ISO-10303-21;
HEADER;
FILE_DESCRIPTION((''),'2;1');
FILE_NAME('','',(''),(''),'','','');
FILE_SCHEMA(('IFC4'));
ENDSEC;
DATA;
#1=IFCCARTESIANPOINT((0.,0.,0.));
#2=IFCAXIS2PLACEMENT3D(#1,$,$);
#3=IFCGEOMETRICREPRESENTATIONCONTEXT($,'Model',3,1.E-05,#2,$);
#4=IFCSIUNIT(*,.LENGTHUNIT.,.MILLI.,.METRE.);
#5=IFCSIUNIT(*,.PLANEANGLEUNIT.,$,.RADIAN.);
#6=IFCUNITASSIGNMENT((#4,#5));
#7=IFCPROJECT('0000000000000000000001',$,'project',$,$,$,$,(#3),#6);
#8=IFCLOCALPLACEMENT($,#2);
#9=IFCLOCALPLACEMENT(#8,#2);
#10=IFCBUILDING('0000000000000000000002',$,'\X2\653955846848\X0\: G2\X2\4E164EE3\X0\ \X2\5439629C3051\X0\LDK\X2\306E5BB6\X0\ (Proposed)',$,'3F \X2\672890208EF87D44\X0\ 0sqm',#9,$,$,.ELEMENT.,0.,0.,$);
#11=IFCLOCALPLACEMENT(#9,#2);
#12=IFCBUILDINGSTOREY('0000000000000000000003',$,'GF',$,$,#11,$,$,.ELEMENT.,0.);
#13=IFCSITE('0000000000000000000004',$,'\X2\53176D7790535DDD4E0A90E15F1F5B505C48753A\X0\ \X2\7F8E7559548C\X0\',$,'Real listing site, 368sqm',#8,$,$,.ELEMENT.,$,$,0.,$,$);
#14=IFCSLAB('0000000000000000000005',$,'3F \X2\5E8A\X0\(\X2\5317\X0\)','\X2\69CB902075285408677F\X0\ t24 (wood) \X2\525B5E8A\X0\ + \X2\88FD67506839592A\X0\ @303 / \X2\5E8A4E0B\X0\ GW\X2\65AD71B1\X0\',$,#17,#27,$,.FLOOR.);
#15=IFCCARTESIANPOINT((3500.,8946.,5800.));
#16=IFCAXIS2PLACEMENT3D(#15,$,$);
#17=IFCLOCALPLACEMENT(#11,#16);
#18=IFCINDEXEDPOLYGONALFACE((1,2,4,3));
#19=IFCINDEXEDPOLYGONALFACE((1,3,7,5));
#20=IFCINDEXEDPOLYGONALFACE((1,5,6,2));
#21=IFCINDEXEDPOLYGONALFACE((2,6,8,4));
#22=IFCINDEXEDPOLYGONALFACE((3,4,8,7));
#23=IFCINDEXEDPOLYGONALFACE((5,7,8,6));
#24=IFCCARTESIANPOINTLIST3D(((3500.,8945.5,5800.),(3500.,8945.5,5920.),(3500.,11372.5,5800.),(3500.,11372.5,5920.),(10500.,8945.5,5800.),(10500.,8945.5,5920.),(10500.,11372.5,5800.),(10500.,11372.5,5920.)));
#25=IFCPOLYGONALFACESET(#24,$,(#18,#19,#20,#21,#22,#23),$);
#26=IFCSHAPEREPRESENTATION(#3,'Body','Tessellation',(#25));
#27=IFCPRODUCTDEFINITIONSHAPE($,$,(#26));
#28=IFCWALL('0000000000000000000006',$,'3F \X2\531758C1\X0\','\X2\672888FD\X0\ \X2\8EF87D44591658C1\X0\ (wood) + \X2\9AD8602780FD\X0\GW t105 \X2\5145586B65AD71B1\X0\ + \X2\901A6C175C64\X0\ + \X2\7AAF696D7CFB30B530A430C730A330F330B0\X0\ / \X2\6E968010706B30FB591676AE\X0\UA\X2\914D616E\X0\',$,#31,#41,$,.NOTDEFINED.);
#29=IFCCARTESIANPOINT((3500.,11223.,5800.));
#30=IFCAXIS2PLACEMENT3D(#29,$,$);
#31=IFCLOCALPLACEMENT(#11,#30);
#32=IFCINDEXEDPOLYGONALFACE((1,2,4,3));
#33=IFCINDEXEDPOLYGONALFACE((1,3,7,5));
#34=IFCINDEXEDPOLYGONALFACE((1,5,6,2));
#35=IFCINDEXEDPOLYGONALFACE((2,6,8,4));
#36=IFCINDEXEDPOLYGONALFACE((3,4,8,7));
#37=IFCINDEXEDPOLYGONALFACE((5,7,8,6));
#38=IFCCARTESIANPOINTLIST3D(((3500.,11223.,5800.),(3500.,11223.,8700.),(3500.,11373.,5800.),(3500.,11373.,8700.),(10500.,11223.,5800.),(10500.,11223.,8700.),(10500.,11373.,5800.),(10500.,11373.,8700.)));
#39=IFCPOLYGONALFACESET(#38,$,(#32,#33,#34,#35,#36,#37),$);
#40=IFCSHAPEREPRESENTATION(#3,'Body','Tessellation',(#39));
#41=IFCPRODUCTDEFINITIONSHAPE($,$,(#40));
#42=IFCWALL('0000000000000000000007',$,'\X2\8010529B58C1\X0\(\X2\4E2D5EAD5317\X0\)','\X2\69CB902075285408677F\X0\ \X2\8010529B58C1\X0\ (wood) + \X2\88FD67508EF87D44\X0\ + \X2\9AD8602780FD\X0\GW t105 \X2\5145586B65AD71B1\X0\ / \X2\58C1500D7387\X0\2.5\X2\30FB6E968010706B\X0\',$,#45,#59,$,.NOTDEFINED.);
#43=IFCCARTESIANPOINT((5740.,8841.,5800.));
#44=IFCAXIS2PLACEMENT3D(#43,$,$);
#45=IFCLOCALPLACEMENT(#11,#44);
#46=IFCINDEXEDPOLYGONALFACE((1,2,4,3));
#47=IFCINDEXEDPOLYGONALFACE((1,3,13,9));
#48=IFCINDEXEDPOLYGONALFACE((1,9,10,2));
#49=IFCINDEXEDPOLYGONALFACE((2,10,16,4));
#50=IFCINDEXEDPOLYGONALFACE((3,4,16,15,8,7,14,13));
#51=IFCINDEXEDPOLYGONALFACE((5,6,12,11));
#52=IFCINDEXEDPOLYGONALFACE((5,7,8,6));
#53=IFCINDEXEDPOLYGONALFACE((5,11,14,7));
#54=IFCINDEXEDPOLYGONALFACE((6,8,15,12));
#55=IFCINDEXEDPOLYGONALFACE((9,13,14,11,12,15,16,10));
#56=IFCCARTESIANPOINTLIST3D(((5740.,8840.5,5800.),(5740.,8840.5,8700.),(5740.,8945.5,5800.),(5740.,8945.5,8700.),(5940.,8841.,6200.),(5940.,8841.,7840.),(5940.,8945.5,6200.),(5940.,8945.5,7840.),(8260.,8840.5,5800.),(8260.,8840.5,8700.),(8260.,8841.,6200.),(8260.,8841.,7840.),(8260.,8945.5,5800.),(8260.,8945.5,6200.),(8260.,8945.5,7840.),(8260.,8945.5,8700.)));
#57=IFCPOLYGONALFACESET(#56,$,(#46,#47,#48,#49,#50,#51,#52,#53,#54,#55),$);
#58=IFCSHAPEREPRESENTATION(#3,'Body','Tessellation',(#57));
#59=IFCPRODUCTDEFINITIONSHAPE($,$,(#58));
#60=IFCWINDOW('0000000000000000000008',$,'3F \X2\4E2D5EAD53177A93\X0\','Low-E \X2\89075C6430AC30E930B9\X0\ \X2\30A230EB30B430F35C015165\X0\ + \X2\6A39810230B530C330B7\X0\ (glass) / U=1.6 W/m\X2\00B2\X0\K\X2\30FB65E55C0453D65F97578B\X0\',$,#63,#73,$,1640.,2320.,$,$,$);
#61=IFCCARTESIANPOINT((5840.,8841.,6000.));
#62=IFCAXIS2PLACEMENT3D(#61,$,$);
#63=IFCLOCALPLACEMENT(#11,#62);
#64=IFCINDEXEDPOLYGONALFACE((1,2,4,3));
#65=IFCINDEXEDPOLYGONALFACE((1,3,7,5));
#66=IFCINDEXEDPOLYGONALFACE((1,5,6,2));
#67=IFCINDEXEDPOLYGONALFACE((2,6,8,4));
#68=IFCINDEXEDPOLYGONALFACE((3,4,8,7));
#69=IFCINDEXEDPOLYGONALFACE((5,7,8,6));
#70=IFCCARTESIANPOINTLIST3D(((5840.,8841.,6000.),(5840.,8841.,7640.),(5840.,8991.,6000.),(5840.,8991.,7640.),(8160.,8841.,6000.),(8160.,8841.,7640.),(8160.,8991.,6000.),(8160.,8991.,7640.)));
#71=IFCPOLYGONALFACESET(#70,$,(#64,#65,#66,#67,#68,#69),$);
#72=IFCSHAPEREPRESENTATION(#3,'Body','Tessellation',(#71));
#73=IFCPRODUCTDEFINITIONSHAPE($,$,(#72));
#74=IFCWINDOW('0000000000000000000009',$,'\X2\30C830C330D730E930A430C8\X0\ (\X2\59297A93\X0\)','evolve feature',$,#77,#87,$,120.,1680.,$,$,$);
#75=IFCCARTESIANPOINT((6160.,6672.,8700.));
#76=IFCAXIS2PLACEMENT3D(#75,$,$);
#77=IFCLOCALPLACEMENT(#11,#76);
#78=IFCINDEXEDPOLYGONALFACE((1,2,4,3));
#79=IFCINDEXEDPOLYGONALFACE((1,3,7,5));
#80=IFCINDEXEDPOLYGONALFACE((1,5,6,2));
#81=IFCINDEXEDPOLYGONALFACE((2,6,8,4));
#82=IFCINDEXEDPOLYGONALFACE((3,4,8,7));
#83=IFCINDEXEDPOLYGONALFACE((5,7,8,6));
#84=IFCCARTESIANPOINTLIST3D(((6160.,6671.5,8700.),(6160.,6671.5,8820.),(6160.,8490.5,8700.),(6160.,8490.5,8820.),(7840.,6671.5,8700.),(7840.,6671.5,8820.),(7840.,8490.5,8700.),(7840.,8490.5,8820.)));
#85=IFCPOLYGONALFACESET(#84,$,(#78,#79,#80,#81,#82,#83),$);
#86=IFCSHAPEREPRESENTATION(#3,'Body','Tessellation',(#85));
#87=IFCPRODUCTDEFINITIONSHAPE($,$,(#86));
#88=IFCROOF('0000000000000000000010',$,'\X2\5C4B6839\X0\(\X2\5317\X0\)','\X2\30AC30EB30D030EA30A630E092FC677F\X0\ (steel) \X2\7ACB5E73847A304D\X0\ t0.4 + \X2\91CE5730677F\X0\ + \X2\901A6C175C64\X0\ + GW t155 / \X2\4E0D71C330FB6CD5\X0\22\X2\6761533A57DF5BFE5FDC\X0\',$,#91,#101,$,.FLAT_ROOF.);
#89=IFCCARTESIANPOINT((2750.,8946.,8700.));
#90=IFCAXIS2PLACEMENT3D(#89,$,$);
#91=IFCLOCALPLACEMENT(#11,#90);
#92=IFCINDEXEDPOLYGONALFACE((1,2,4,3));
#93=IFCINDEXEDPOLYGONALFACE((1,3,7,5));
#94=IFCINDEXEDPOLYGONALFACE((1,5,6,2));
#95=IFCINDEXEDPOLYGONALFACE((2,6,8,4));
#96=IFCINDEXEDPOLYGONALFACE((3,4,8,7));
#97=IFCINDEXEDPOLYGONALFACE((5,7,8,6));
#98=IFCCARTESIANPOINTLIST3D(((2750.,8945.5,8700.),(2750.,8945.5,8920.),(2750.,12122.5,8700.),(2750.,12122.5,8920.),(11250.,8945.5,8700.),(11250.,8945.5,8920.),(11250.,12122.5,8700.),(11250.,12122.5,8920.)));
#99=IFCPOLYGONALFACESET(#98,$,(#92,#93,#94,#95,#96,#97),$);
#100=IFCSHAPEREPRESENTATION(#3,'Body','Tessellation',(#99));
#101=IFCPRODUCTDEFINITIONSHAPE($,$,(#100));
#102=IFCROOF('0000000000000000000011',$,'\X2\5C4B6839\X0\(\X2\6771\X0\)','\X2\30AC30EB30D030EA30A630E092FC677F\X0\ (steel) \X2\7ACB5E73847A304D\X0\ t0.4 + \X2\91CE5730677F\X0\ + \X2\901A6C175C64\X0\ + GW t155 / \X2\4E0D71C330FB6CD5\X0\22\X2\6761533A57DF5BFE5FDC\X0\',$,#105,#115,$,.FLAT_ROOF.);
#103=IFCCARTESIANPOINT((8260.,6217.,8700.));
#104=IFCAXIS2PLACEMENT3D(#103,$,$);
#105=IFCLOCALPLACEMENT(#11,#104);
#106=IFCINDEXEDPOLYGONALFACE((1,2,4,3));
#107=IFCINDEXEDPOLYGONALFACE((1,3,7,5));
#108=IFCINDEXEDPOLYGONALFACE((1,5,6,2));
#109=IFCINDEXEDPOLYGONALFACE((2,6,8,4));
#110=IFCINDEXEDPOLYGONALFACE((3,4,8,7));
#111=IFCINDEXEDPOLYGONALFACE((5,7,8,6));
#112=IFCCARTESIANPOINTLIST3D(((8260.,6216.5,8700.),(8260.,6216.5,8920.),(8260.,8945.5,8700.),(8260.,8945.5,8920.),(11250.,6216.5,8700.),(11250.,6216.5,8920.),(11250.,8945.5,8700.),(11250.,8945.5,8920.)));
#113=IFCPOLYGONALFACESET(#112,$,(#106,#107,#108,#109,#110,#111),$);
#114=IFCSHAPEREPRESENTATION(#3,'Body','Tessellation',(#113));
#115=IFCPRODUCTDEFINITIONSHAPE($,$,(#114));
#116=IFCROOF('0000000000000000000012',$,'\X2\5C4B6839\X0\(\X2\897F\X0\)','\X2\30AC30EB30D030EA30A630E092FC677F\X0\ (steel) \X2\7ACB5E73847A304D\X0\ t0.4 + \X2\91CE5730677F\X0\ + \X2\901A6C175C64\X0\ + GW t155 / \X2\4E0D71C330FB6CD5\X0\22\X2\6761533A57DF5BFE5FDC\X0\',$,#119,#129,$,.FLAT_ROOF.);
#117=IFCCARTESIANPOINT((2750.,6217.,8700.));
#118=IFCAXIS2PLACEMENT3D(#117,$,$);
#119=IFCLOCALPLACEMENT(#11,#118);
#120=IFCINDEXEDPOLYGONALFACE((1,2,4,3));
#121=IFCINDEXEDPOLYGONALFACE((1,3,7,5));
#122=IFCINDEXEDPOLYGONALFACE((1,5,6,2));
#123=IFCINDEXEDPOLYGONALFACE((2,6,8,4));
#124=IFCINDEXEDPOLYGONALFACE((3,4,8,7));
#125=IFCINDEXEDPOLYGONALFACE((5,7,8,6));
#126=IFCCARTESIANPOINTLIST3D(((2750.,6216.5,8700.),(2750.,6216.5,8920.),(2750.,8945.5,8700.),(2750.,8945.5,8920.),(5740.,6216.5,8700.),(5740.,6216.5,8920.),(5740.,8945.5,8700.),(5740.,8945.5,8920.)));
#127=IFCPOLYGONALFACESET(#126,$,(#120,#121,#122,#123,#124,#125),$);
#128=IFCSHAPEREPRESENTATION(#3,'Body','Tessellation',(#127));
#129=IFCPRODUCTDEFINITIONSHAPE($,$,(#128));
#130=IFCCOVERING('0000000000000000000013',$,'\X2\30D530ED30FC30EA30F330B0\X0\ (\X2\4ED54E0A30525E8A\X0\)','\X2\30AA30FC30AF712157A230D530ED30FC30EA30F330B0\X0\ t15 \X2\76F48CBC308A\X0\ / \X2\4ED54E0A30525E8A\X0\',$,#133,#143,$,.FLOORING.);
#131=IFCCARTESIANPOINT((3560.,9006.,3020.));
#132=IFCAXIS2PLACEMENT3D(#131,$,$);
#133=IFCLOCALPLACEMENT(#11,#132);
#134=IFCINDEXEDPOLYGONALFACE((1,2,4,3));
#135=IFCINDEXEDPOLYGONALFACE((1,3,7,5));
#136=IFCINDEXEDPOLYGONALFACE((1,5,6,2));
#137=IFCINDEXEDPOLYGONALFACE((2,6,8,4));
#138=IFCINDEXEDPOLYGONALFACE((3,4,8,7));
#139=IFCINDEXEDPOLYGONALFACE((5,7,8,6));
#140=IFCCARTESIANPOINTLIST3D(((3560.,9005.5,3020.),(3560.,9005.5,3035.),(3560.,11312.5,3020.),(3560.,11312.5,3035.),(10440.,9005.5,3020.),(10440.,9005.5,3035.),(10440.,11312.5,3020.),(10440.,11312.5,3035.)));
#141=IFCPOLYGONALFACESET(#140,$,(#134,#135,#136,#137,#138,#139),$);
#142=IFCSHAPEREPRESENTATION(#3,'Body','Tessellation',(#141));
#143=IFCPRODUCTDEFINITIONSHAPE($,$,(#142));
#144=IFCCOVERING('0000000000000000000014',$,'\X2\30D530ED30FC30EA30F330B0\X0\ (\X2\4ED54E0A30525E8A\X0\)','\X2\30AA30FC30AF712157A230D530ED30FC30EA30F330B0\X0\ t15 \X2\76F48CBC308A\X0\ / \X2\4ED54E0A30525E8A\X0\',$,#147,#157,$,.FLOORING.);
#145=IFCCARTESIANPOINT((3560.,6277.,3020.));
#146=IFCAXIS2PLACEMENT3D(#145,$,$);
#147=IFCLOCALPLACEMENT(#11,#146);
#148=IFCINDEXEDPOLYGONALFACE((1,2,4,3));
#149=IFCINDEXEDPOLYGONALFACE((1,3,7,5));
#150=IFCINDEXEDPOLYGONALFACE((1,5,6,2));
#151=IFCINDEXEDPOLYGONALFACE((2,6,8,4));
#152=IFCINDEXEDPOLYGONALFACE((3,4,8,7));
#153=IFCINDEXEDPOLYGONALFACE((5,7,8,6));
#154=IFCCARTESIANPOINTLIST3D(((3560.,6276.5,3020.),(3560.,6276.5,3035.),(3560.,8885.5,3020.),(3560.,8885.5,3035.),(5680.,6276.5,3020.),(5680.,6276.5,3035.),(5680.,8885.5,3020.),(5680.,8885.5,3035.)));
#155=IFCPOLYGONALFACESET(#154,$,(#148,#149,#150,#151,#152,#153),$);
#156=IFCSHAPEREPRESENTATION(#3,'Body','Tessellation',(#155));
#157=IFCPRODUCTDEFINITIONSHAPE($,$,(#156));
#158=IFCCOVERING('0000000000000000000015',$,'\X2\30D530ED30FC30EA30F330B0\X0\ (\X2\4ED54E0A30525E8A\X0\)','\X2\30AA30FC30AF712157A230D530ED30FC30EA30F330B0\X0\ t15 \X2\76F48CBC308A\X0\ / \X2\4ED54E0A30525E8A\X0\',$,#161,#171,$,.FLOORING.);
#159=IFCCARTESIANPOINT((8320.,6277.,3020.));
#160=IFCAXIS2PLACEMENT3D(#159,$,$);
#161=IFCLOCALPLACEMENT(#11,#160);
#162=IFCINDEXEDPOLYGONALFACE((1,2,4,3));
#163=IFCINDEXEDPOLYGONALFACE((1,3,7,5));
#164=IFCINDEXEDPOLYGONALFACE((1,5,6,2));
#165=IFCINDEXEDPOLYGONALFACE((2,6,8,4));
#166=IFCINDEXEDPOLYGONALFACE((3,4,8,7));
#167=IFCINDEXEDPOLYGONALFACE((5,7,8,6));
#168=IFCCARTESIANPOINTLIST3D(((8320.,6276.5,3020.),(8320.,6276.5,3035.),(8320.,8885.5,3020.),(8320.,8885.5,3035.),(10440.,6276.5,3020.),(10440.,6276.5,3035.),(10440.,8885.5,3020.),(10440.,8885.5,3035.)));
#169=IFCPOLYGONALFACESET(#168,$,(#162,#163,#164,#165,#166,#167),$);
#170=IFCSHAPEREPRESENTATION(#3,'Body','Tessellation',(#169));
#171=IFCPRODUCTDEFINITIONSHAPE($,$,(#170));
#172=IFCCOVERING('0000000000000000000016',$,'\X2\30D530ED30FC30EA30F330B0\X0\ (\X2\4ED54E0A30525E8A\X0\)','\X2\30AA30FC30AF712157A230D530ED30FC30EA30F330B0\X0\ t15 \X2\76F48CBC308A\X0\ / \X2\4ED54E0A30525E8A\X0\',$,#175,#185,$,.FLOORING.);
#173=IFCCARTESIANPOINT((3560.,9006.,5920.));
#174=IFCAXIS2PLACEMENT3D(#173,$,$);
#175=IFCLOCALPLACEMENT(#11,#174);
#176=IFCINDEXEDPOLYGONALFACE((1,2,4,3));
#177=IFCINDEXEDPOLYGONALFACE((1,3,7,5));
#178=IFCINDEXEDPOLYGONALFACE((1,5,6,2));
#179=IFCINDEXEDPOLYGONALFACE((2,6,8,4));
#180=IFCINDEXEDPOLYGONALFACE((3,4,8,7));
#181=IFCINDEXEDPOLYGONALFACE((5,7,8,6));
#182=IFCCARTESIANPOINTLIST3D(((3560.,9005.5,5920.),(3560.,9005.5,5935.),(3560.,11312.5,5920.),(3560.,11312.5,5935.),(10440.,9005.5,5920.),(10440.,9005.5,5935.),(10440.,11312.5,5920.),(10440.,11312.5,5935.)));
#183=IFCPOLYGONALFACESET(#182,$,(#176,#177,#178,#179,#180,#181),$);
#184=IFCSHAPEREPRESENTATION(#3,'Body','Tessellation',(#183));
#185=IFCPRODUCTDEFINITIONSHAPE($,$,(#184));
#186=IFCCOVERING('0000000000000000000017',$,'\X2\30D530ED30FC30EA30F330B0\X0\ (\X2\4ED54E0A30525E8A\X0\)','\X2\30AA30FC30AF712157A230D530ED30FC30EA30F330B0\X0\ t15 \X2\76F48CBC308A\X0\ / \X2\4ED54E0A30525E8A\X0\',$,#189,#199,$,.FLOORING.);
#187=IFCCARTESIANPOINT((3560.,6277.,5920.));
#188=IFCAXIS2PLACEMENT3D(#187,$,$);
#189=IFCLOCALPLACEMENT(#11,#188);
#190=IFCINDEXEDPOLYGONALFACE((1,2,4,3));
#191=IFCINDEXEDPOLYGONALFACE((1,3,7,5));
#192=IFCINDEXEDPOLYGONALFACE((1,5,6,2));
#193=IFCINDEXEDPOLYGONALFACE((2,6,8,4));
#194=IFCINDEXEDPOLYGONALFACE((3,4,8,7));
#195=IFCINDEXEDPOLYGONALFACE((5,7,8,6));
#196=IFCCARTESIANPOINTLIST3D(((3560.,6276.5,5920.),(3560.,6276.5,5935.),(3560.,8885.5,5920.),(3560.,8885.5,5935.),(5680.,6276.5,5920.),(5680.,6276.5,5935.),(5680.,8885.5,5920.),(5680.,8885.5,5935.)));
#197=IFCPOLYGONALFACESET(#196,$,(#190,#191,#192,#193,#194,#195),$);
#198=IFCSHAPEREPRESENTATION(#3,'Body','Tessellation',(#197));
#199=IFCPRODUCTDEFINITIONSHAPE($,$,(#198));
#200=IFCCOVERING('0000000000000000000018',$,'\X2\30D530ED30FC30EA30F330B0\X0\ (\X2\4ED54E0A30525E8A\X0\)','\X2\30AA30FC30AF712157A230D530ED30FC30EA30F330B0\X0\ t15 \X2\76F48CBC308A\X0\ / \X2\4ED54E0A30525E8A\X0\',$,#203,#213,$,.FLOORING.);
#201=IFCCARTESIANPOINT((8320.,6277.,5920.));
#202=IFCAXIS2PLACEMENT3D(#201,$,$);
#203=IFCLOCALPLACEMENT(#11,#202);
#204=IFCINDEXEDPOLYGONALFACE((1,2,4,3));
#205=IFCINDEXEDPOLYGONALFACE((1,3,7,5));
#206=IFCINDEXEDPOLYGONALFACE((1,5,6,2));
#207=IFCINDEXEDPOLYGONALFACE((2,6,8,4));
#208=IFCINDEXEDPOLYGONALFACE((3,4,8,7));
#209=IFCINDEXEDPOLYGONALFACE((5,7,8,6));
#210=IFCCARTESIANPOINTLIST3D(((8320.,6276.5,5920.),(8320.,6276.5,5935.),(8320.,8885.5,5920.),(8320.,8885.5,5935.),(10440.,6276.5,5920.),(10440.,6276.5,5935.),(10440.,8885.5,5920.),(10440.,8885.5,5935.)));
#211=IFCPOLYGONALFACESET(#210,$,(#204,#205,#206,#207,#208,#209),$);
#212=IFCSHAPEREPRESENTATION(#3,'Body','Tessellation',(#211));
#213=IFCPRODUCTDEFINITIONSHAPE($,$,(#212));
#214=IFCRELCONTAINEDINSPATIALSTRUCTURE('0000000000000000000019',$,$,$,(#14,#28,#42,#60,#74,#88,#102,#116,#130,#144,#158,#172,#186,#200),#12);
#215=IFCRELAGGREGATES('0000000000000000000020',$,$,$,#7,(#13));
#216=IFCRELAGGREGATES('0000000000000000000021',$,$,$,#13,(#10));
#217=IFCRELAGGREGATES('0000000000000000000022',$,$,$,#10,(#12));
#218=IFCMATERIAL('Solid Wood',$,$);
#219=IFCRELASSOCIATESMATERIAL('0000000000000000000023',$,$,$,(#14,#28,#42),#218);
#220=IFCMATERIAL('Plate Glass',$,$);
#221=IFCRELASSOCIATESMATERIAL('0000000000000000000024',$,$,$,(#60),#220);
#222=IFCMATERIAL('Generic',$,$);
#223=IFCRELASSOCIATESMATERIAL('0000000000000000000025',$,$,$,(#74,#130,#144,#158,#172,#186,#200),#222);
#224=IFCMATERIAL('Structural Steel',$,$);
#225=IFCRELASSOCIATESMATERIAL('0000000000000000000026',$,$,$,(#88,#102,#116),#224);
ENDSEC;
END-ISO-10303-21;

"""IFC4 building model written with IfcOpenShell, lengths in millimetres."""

from ifc_helpers import new_model, si_unit, frame, frame_2d, origin, place, context, project, spatial, rectangle, extrude, material, element, fill, save


model = new_model("IFC4")

# Units and contexts
model_context = context("Model", 3, precision=1e-05, world=origin())
ifc_project = project(units=[si_unit("LENGTHUNIT", "METRE", prefix="MILLI"), si_unit("PLANEANGLEUNIT", "RADIAN")], contexts=[model_context])

# Site, building, storey
site_placement = place(None, origin())
site = spatial("IfcSite", under=ifc_project, at=site_placement, Name="北海道川上郡弟子屈町 美留和", ObjectType="Real listing site, 368sqm", CompositionType="ELEMENT", RefElevation=0.0)
building_placement = place(site_placement, origin())
building = spatial("IfcBuilding", under=site, at=building_placement, Name="改善案: G2世代 吹抜けLDKの家 (Proposed)", ObjectType="3F 木造軸組 0sqm", CompositionType="ELEMENT", ElevationOfRefHeight=0.0, ElevationOfTerrain=0.0)
storey_placement = place(building_placement, origin())
storey = spatial("IfcBuildingStorey", under=building, at=storey_placement, Name="GF", CompositionType="ELEMENT", Elevation=0.0)

# Slab
ifc_material_1 = material(Name="Solid Wood")
slab_placement = place(storey_placement, frame((3500.0, 8946.0, 5800.0)))
element("IfcSlab", 1, at=slab_placement, inside=storey, material=ifc_material_1, Name="3F 床(北)", Description="構造用合板 t24 (wood) 剛床 + 製材根太 @303 / 床下 GW断熱", PredefinedType="FLOOR", context=model_context, shape_type="SweptSolid", body=[
    extrude(rectangle(XDim=7000.0, YDim=2427.0, at=frame_2d((3500.0, 1213.0))), frame((3500.0, 8946.0, 5800.0)), (0.0, 0.0, 1.0), 120.0),
])

# Wall
wall_1_placement = place(storey_placement, frame((3500.0, 11223.0, 5800.0)))
element("IfcWall", 2, at=wall_1_placement, inside=storey, material=ifc_material_1, Name="3F 北壁", Description="木製 軸組外壁 (wood) + 高性能GW t105 充填断熱 + 通気層 + 窯業系サイディング / 準耐火・外皮UA配慮", PredefinedType="NOTDEFINED", context=model_context, shape_type="SweptSolid", body=[
    extrude(rectangle(XDim=7000.0, YDim=150.0, at=frame_2d((3500.0, 75.0))), frame((3500.0, 11223.0, 5800.0)), (0.0, 0.0, 1.0), 2900.0),
])

# Wall, opening, window
wall_2_placement = place(storey_placement, frame((5740.0, 8841.0, 5800.0)))
wall_2 = element("IfcWall", 3, at=wall_2_placement, inside=storey, material=ifc_material_1, Name="耐力壁(中庭北)", Description="構造用合板 耐力壁 (wood) + 製材軸組 + 高性能GW t105 充填断熱 / 壁倍率2.5・準耐火", PredefinedType="NOTDEFINED", context=model_context, shape_type="SweptSolid", body=[
    extrude(rectangle(XDim=2520.0, YDim=105.0, at=frame_2d((1260.0, 52.0))), frame((5740.0, 8841.0, 5800.0)), (0.0, 0.0, 1.0), 2900.0),
])
opening_placement = place(storey_placement, frame((5840.0, 8841.0, 6000.0)))
opening = element("IfcOpeningElement", 4, at=opening_placement, cuts=wall_2, PredefinedType="NOTDEFINED", context=model_context, shape_type="SweptSolid", body=[
    extrude(rectangle(XDim=2320.0, YDim=150.0, at=frame_2d((1160.0, 75.0))), frame((5840.0, 8841.0, 6000.0)), (0.0, 0.0, 1.0), 1640.0),
])
ifc_material_2 = material(Name="Plate Glass")
window_1_placement = place(storey_placement, frame((5840.0, 8841.0, 6000.0)))
window_1 = element("IfcWindow", 5, at=window_1_placement, inside=storey, material=ifc_material_2, Name="3F 中庭北窓", Description="Low-E 複層ガラス アルゴン封入 + 樹脂サッシ (glass) / U=1.6 W/m²K・日射取得型", OverallHeight=1640.0, OverallWidth=2320.0, context=model_context, shape_type="SweptSolid", body=[
    extrude(rectangle(XDim=2320.0, YDim=150.0, at=frame_2d((1160.0, 75.0))), frame((5840.0, 8841.0, 6000.0)), (0.0, 0.0, 1.0), 1640.0),
])
fill(opening, window_1)

# Window
ifc_material_3 = material(Name="Generic")
window_2_placement = place(storey_placement, frame((6160.0, 6672.0, 8700.0)))
element("IfcWindow", 6, at=window_2_placement, inside=storey, material=ifc_material_3, Name="トップライト (天窓)", Description="evolve feature", OverallHeight=120.0, OverallWidth=1680.0, context=model_context, shape_type="SweptSolid", body=[
    extrude(rectangle(XDim=1680.0, YDim=1819.0, at=frame_2d((840.0, 909.0))), frame((6160.0, 6672.0, 8700.0)), (0.0, 0.0, 1.0), 120.0),
])

# Roofs
ifc_material_4 = material(Name="Structural Steel")
roof_1_placement = place(storey_placement, frame((2750.0, 8946.0, 8700.0)))
element("IfcRoof", 7, at=roof_1_placement, inside=storey, material=ifc_material_4, Name="屋根(北)", Description="ガルバリウム鋼板 (steel) 立平葺き t0.4 + 野地板 + 通気層 + GW t155 / 不燃・法22条区域対応", PredefinedType="FLAT_ROOF", context=model_context, shape_type="SweptSolid", body=[
    extrude(rectangle(XDim=8500.0, YDim=3177.0, at=frame_2d((4250.0, 1588.0))), frame((2750.0, 8946.0, 8700.0)), (0.0, 0.0, 1.0), 220.0),
])
roof_2_placement = place(storey_placement, frame((8260.0, 6217.0, 8700.0)))
element("IfcRoof", 8, at=roof_2_placement, inside=storey, material=ifc_material_4, Name="屋根(東)", Description="ガルバリウム鋼板 (steel) 立平葺き t0.4 + 野地板 + 通気層 + GW t155 / 不燃・法22条区域対応", PredefinedType="FLAT_ROOF", context=model_context, shape_type="SweptSolid", body=[
    extrude(rectangle(XDim=2990.0, YDim=2729.0, at=frame_2d((1495.0, 1364.0))), frame((8260.0, 6217.0, 8700.0)), (0.0, 0.0, 1.0), 220.0),
])
roof_3_placement = place(storey_placement, frame((2750.0, 6217.0, 8700.0)))
element("IfcRoof", 9, at=roof_3_placement, inside=storey, material=ifc_material_4, Name="屋根(西)", Description="ガルバリウム鋼板 (steel) 立平葺き t0.4 + 野地板 + 通気層 + GW t155 / 不燃・法22条区域対応", PredefinedType="FLAT_ROOF", context=model_context, shape_type="SweptSolid", body=[
    extrude(rectangle(XDim=2990.0, YDim=2729.0, at=frame_2d((1495.0, 1364.0))), frame((2750.0, 6217.0, 8700.0)), (0.0, 0.0, 1.0), 220.0),
])

# Coverings
covering_1_placement = place(storey_placement, frame((3560.0, 9006.0, 3020.0)))
element("IfcCovering", 10, at=covering_1_placement, inside=storey, material=ifc_material_3, Name="フローリング (仕上げ床)", Description="オーク無垢フローリング t15 直貼り / 仕上げ床", PredefinedType="FLOORING", context=model_context, shape_type="SweptSolid", body=[
    extrude(rectangle(XDim=6880.0, YDim=2307.0, at=frame_2d((3440.0, 1153.0))), frame((3560.0, 9006.0, 3020.0)), (0.0, 0.0, 1.0), 15.0),
])
covering_2_placement = place(storey_placement, frame((3560.0, 6277.0, 3020.0)))
element("IfcCovering", 11, at=covering_2_placement, inside=storey, material=ifc_material_3, Name="フローリング (仕上げ床)", Description="オーク無垢フローリング t15 直貼り / 仕上げ床", PredefinedType="FLOORING", context=model_context, shape_type="SweptSolid", body=[
    extrude(rectangle(XDim=2120.0, YDim=2609.0, at=frame_2d((1060.0, 1304.0))), frame((3560.0, 6277.0, 3020.0)), (0.0, 0.0, 1.0), 15.0),
])
covering_3_placement = place(storey_placement, frame((8320.0, 6277.0, 3020.0)))
element("IfcCovering", 12, at=covering_3_placement, inside=storey, material=ifc_material_3, Name="フローリング (仕上げ床)", Description="オーク無垢フローリング t15 直貼り / 仕上げ床", PredefinedType="FLOORING", context=model_context, shape_type="SweptSolid", body=[
    extrude(rectangle(XDim=2120.0, YDim=2609.0, at=frame_2d((1060.0, 1304.0))), frame((8320.0, 6277.0, 3020.0)), (0.0, 0.0, 1.0), 15.0),
])
covering_4_placement = place(storey_placement, frame((3560.0, 9006.0, 5920.0)))
element("IfcCovering", 13, at=covering_4_placement, inside=storey, material=ifc_material_3, Name="フローリング (仕上げ床)", Description="オーク無垢フローリング t15 直貼り / 仕上げ床", PredefinedType="FLOORING", context=model_context, shape_type="SweptSolid", body=[
    extrude(rectangle(XDim=6880.0, YDim=2307.0, at=frame_2d((3440.0, 1153.0))), frame((3560.0, 9006.0, 5920.0)), (0.0, 0.0, 1.0), 15.0),
])
covering_5_placement = place(storey_placement, frame((3560.0, 6277.0, 5920.0)))
element("IfcCovering", 14, at=covering_5_placement, inside=storey, material=ifc_material_3, Name="フローリング (仕上げ床)", Description="オーク無垢フローリング t15 直貼り / 仕上げ床", PredefinedType="FLOORING", context=model_context, shape_type="SweptSolid", body=[
    extrude(rectangle(XDim=2120.0, YDim=2609.0, at=frame_2d((1060.0, 1304.0))), frame((3560.0, 6277.0, 5920.0)), (0.0, 0.0, 1.0), 15.0),
])
covering_6_placement = place(storey_placement, frame((8320.0, 6277.0, 5920.0)))
element("IfcCovering", 15, at=covering_6_placement, inside=storey, material=ifc_material_3, Name="フローリング (仕上げ床)", Description="オーク無垢フローリング t15 直貼り / 仕上げ床", PredefinedType="FLOORING", context=model_context, shape_type="SweptSolid", body=[
    extrude(rectangle(XDim=2120.0, YDim=2609.0, at=frame_2d((1060.0, 1304.0))), frame((8320.0, 6277.0, 5920.0)), (0.0, 0.0, 1.0), 15.0),
])

save(model, "model.ifc")
